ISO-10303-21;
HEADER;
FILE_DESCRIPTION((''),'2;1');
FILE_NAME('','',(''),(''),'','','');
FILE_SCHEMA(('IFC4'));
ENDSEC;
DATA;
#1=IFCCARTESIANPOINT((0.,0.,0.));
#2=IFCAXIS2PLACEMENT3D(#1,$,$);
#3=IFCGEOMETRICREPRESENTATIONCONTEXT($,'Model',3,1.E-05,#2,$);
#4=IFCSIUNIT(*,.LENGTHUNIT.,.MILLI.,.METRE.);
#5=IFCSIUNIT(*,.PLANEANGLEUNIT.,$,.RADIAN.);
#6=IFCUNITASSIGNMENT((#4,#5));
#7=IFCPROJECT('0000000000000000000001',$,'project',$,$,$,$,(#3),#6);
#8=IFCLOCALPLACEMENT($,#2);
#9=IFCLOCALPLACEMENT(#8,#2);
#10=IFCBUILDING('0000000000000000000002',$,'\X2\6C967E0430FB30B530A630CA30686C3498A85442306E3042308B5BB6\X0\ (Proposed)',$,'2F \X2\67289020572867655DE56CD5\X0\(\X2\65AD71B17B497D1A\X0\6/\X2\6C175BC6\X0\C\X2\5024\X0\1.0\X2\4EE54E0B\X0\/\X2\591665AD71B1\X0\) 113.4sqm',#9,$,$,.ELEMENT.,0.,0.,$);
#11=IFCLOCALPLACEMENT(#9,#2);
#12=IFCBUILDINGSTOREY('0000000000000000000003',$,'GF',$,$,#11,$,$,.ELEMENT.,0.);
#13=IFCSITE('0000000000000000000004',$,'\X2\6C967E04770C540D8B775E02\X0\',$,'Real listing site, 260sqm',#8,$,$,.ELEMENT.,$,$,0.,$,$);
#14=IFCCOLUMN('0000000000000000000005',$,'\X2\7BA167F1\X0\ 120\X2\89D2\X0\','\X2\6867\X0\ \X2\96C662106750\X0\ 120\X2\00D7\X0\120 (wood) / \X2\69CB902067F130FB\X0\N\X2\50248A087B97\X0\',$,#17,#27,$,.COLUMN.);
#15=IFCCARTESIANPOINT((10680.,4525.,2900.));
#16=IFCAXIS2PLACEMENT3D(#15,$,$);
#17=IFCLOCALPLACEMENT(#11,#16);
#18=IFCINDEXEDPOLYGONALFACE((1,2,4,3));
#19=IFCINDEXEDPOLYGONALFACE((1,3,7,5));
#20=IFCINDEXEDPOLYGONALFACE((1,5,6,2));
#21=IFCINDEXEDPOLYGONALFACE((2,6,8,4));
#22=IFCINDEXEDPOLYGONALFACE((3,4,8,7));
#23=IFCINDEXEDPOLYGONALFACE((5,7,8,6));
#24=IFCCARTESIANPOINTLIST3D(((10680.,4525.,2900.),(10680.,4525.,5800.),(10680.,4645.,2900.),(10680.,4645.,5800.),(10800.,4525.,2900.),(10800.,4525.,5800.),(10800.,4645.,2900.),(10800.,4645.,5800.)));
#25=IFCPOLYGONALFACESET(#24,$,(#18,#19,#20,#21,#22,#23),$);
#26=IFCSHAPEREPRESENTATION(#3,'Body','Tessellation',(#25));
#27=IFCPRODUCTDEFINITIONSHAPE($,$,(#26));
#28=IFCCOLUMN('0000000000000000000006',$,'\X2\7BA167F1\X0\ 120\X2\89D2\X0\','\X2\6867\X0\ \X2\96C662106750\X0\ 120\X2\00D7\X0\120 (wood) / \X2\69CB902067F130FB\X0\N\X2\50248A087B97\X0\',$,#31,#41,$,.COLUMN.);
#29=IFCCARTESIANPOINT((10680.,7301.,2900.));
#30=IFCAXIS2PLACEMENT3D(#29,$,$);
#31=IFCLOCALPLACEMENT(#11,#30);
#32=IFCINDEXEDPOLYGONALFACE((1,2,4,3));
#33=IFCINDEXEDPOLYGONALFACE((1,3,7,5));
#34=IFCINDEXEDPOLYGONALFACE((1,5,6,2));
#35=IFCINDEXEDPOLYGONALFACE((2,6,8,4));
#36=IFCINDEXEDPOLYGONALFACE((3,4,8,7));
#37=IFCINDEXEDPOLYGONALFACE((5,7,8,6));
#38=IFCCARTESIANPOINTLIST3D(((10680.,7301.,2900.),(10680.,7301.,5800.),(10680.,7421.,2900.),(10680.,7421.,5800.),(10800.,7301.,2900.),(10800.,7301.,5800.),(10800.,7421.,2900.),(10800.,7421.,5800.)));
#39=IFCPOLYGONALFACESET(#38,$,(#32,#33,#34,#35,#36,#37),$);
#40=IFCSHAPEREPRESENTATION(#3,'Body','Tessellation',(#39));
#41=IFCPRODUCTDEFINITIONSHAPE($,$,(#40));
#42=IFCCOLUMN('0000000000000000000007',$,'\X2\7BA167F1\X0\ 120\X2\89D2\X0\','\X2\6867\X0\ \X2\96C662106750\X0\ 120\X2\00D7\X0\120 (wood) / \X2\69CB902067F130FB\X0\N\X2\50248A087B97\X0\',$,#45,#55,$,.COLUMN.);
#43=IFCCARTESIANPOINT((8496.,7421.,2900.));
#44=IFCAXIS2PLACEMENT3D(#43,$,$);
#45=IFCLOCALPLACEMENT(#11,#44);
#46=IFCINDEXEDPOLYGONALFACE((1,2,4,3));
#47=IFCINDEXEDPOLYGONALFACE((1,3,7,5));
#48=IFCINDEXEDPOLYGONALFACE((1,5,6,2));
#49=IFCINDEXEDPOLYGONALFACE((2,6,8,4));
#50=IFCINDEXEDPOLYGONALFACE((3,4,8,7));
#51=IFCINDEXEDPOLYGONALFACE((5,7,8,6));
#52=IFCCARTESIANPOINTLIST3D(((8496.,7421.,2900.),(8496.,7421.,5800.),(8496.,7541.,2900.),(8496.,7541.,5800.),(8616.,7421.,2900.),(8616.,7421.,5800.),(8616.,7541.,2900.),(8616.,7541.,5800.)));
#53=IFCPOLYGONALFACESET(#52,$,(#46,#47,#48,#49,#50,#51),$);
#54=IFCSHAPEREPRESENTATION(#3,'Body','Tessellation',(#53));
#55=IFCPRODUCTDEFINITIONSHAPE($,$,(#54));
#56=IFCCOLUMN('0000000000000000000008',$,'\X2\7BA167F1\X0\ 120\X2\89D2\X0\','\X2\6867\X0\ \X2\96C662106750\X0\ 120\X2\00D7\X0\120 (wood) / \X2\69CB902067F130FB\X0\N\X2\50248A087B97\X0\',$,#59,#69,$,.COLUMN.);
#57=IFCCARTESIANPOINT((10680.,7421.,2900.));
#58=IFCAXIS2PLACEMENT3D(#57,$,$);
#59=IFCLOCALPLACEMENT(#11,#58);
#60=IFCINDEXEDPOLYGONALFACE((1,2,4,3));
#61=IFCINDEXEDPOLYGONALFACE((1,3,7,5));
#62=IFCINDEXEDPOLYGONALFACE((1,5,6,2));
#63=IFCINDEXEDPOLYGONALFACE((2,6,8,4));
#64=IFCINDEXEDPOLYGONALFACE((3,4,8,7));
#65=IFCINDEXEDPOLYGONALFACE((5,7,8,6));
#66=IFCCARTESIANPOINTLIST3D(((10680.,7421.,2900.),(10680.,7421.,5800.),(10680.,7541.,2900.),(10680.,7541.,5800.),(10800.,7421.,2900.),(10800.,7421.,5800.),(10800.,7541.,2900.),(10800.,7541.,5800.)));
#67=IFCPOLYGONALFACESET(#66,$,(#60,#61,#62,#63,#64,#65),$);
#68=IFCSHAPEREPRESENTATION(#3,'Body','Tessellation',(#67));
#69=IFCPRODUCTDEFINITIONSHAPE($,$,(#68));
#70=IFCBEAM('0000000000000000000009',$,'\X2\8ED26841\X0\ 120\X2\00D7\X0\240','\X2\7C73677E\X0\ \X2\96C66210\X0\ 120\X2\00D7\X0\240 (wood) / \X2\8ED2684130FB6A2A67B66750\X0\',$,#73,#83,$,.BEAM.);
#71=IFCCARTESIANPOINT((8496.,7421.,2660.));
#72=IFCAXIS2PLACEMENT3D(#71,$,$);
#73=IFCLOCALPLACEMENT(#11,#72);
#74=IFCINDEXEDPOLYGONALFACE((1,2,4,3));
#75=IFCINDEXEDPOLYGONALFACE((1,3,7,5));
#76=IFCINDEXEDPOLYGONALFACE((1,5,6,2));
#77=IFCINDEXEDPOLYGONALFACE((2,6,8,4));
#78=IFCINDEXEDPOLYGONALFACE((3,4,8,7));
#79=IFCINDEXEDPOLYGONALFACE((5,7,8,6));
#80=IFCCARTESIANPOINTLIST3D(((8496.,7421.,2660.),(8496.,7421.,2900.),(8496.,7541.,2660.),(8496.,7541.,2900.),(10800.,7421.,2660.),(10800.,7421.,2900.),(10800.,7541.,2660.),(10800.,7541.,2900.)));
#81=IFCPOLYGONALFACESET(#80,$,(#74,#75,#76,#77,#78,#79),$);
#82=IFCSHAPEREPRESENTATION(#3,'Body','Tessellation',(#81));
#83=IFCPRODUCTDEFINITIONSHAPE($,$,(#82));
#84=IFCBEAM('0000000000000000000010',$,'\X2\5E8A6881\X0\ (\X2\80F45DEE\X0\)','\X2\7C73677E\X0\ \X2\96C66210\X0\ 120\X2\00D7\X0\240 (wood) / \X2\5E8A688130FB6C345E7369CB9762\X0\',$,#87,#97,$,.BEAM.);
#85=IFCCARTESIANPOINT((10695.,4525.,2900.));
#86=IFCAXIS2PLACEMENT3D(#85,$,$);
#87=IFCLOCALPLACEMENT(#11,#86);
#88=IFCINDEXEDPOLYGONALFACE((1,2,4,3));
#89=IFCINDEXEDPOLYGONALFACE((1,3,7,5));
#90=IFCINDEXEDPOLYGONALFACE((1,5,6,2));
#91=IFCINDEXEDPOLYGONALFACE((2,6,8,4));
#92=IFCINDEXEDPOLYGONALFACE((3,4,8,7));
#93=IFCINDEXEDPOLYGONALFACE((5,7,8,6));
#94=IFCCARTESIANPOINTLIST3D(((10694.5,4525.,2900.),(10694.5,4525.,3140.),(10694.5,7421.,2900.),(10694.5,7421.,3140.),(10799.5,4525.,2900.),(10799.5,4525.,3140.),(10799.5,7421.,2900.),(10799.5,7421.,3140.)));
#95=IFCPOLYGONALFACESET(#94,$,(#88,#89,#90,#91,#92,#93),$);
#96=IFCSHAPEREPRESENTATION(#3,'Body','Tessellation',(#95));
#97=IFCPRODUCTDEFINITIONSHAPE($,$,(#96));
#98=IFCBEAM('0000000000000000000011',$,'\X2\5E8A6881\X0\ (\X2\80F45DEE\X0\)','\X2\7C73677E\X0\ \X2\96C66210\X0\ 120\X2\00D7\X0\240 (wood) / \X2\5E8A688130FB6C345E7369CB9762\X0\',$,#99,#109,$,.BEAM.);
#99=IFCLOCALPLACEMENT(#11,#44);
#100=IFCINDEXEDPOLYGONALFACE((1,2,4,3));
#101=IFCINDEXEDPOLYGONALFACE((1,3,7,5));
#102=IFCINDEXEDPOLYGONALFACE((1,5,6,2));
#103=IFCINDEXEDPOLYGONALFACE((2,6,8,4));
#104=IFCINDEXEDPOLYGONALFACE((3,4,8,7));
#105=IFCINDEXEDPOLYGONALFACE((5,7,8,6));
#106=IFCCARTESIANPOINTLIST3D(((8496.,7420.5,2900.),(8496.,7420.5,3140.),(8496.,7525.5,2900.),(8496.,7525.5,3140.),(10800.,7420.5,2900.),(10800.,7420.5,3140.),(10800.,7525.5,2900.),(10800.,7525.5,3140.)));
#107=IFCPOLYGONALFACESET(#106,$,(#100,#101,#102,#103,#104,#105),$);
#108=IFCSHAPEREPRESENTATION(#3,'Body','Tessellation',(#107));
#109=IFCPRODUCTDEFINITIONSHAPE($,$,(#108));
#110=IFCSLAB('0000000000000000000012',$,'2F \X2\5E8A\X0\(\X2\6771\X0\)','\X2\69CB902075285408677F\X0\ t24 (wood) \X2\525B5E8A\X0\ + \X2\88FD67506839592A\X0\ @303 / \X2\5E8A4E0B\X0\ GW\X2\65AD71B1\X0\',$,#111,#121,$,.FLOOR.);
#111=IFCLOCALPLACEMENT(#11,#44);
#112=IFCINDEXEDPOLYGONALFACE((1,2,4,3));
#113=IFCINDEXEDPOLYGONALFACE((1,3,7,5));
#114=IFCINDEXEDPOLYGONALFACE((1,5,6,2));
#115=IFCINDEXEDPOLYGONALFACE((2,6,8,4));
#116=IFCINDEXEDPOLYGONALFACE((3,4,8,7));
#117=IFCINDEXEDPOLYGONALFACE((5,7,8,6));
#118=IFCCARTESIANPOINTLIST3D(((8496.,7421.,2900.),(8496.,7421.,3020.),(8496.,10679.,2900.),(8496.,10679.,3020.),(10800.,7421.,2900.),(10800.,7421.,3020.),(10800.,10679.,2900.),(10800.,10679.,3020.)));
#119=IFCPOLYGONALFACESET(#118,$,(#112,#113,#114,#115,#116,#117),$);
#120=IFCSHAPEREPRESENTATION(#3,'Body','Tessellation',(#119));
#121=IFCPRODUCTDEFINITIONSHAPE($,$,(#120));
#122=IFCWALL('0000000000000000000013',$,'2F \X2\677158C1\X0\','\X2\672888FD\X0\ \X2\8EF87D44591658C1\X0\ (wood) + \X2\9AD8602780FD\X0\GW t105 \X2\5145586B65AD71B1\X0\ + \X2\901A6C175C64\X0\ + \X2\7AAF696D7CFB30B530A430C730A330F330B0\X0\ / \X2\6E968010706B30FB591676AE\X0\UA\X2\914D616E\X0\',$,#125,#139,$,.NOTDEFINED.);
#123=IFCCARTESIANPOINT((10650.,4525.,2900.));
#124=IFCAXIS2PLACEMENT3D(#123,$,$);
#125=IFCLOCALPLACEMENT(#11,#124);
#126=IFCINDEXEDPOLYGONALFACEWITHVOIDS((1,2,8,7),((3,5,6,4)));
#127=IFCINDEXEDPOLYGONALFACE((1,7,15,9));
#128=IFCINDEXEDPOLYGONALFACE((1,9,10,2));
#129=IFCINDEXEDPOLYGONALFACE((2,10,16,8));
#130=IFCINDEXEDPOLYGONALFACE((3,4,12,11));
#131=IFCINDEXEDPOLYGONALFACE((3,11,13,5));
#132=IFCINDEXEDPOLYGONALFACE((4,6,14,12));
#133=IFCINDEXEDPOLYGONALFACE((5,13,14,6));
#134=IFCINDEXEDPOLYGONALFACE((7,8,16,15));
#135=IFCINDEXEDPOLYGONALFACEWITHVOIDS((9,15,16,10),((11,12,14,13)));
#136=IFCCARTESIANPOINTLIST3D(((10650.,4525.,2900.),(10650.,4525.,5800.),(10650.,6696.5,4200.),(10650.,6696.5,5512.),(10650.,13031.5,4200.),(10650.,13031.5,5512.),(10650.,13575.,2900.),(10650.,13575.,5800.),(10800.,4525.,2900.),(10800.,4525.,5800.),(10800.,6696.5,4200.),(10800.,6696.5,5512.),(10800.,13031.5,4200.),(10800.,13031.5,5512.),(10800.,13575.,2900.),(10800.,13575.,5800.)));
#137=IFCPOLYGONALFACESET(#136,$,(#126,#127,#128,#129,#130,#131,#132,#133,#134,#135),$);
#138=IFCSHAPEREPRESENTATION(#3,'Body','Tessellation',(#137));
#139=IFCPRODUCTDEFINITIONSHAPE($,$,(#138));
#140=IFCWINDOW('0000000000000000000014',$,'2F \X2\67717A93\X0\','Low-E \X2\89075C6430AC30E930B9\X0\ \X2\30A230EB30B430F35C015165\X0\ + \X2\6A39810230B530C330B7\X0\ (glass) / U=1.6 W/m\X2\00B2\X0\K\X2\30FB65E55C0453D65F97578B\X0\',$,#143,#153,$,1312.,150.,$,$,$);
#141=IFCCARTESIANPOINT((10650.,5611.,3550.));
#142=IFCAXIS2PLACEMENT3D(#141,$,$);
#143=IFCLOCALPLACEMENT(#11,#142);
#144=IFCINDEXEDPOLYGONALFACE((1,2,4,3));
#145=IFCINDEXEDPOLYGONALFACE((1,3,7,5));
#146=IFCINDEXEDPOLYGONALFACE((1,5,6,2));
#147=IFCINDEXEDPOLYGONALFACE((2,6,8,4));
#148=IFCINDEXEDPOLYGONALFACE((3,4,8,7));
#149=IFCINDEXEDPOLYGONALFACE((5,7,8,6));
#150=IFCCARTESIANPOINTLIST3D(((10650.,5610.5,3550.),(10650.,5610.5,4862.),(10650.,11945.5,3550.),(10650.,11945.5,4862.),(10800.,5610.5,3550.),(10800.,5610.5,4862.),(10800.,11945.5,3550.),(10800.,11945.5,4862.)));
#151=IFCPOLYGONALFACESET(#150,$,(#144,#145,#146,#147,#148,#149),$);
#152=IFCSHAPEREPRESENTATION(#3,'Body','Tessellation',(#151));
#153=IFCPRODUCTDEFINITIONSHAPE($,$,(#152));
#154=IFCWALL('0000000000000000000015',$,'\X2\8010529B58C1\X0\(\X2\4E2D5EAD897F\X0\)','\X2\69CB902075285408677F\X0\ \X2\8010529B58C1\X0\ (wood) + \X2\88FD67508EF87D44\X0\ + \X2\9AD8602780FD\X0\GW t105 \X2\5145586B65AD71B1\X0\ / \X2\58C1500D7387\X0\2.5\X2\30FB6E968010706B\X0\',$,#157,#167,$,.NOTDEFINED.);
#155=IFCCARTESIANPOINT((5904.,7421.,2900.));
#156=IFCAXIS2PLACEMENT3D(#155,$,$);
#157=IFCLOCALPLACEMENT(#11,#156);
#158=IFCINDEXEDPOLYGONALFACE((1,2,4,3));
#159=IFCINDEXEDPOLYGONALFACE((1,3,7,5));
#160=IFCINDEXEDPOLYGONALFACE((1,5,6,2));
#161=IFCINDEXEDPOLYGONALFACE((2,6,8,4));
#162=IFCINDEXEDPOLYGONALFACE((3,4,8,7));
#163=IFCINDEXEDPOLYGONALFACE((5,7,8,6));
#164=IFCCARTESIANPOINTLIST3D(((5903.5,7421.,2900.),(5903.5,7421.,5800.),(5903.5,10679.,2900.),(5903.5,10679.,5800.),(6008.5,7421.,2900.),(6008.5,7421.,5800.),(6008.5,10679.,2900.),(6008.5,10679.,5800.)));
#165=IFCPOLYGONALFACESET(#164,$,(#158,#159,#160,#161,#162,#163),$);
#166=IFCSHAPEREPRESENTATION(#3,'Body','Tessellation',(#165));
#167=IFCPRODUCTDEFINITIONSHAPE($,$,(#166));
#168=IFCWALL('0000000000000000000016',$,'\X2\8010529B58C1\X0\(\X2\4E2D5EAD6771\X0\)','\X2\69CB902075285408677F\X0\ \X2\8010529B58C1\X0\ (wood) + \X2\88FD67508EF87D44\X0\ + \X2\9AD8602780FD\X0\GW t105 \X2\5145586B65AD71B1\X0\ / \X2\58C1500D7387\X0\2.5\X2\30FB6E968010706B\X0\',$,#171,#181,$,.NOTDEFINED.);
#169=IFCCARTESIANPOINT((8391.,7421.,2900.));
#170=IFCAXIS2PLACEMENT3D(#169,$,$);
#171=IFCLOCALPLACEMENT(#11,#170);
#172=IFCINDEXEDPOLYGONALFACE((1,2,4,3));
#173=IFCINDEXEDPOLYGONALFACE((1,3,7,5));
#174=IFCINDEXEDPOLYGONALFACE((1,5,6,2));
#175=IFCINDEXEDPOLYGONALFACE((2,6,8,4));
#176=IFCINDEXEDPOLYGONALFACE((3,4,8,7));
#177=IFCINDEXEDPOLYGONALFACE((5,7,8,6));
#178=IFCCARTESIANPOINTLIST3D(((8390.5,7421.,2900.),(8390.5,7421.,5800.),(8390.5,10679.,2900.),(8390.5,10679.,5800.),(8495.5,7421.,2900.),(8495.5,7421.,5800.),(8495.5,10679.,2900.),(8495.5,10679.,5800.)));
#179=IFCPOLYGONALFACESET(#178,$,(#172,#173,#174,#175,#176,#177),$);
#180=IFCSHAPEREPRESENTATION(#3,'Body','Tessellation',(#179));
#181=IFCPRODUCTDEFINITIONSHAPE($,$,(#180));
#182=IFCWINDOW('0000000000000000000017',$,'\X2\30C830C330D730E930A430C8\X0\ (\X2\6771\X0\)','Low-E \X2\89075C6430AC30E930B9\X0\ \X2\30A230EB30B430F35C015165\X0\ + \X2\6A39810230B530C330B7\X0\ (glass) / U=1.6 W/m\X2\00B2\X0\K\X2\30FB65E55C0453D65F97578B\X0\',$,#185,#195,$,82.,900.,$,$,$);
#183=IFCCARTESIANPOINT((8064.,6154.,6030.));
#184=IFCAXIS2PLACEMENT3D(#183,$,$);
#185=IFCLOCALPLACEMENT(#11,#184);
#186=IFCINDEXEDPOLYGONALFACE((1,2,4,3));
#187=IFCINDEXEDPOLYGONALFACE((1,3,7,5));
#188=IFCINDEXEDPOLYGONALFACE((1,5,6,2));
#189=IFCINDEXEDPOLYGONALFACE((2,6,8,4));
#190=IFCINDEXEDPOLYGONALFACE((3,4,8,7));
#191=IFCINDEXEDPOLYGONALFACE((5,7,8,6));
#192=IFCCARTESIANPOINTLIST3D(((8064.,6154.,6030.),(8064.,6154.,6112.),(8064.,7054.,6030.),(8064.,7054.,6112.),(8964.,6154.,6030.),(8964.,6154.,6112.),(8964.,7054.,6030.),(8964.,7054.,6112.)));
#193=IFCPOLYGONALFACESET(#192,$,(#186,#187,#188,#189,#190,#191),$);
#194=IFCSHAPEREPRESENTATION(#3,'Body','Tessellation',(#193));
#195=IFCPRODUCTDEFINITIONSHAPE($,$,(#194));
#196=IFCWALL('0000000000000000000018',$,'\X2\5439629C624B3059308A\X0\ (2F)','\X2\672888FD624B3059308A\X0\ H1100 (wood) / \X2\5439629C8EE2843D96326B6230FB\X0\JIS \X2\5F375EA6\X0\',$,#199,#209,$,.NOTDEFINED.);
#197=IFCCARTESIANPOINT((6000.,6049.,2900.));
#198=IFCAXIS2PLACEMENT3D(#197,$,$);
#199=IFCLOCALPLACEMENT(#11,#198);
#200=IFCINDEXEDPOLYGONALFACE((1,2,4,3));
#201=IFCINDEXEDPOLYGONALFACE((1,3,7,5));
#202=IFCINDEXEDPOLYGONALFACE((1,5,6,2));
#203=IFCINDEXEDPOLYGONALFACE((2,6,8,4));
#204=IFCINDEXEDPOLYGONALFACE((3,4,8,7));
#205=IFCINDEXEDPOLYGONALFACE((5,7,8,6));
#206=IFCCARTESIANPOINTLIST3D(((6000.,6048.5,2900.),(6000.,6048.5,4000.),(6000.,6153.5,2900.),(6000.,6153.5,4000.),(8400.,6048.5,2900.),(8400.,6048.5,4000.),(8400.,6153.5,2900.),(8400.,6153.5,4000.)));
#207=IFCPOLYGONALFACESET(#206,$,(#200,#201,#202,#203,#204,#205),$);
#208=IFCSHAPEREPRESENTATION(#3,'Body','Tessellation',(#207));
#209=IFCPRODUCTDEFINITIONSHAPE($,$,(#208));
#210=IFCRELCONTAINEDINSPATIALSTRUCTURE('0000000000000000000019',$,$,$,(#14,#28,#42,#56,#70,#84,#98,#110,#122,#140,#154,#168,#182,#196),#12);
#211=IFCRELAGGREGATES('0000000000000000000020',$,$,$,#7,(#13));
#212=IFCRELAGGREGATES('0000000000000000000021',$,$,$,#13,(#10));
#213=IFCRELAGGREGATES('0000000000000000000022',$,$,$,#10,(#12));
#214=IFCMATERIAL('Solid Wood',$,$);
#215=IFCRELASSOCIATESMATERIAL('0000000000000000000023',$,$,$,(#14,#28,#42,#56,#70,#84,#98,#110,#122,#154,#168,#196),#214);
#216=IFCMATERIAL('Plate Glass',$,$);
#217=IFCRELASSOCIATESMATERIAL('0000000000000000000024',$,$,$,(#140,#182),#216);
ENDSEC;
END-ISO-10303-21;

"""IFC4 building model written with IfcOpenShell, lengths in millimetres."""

from ifc_helpers import new_model, si_unit, frame, frame_2d, origin, place, context, project, spatial, rectangle, extrude, material, element, fill, save


model = new_model("IFC4")

# Units and contexts
model_context = context("Model", 3, precision=1e-05, world=origin())
ifc_project = project(units=[si_unit("LENGTHUNIT", "METRE", prefix="MILLI"), si_unit("PLANEANGLEUNIT", "RADIAN")], contexts=[model_context])

# Site, building, storey
site_placement = place(None, origin())
site = spatial("IfcSite", under=ifc_project, at=site_placement, Name="沖縄県名護市", ObjectType="Real listing site, 260sqm", CompositionType="ELEMENT", RefElevation=0.0)
building_placement = place(site_placement, origin())
building = spatial("IfcBuilding", under=site, at=building_placement, Name="沖縄・サウナと水風呂のある家 (Proposed)", ObjectType="2F 木造在来工法(断熱等級6/気密C値1.0以下/外断熱) 113.4sqm", CompositionType="ELEMENT", ElevationOfRefHeight=0.0, ElevationOfTerrain=0.0)
storey_placement = place(building_placement, origin())
storey = spatial("IfcBuildingStorey", under=building, at=storey_placement, Name="GF", CompositionType="ELEMENT", Elevation=0.0)

# Columns
ifc_material_1 = material(Name="Solid Wood")
column_1_placement = place(storey_placement, frame((10680.0, 4525.0, 2900.0)))
element("IfcColumn", 1, at=column_1_placement, inside=storey, material=ifc_material_1, Name="管柱 120角", Description="桧 集成材 120×120 (wood) / 構造柱・N値計算", PredefinedType="COLUMN", context=model_context, shape_type="SweptSolid", body=[
    extrude(rectangle(XDim=120.0, YDim=120.0, at=frame_2d((60.0, 60.0))), frame((10680.0, 4525.0, 2900.0)), (0.0, 0.0, 1.0), 2900.0),
])
column_2_placement = place(storey_placement, frame((10680.0, 7301.0, 2900.0)))
element("IfcColumn", 2, at=column_2_placement, inside=storey, material=ifc_material_1, Name="管柱 120角", Description="桧 集成材 120×120 (wood) / 構造柱・N値計算", PredefinedType="COLUMN", context=model_context, shape_type="SweptSolid", body=[
    extrude(rectangle(XDim=120.0, YDim=120.0, at=frame_2d((60.0, 60.0))), frame((10680.0, 7301.0, 2900.0)), (0.0, 0.0, 1.0), 2900.0),
])
column_3_placement = place(storey_placement, frame((8496.0, 7421.0, 2900.0)))
element("IfcColumn", 3, at=column_3_placement, inside=storey, material=ifc_material_1, Name="管柱 120角", Description="桧 集成材 120×120 (wood) / 構造柱・N値計算", PredefinedType="COLUMN", context=model_context, shape_type="SweptSolid", body=[
    extrude(rectangle(XDim=120.0, YDim=120.0, at=frame_2d((60.0, 60.0))), frame((8496.0, 7421.0, 2900.0)), (0.0, 0.0, 1.0), 2900.0),
])
column_4_placement = place(storey_placement, frame((10680.0, 7421.0, 2900.0)))
element("IfcColumn", 4, at=column_4_placement, inside=storey, material=ifc_material_1, Name="管柱 120角", Description="桧 集成材 120×120 (wood) / 構造柱・N値計算", PredefinedType="COLUMN", context=model_context, shape_type="SweptSolid", body=[
    extrude(rectangle(XDim=120.0, YDim=120.0, at=frame_2d((60.0, 60.0))), frame((10680.0, 7421.0, 2900.0)), (0.0, 0.0, 1.0), 2900.0),
])

# Beams
beam_1_placement = place(storey_placement, frame((8496.0, 7421.0, 2660.0)))
element("IfcBeam", 5, at=beam_1_placement, inside=storey, material=ifc_material_1, Name="軒桁 120×240", Description="米松 集成 120×240 (wood) / 軒桁・横架材", PredefinedType="BEAM", context=model_context, shape_type="SweptSolid", body=[
    extrude(rectangle(XDim=2304.0, YDim=120.0, at=frame_2d((1152.0, 60.0))), frame((8496.0, 7421.0, 2660.0)), (0.0, 0.0, 1.0), 240.0),
])
beam_2_placement = place(storey_placement, frame((10695.0, 4525.0, 2900.0)))
element("IfcBeam", 6, at=beam_2_placement, inside=storey, material=ifc_material_1, Name="床梁 (胴差)", Description="米松 集成 120×240 (wood) / 床梁・水平構面", PredefinedType="BEAM", context=model_context, shape_type="SweptSolid", body=[
    extrude(rectangle(XDim=105.0, YDim=2896.0, at=frame_2d((52.0, 1448.0))), frame((10695.0, 4525.0, 2900.0)), (0.0, 0.0, 1.0), 240.0),
])
beam_3_placement = place(storey_placement, frame((8496.0, 7421.0, 2900.0)))
element("IfcBeam", 7, at=beam_3_placement, inside=storey, material=ifc_material_1, Name="床梁 (胴差)", Description="米松 集成 120×240 (wood) / 床梁・水平構面", PredefinedType="BEAM", context=model_context, shape_type="SweptSolid", body=[
    extrude(rectangle(XDim=2304.0, YDim=105.0, at=frame_2d((1152.0, 52.0))), frame((8496.0, 7421.0, 2900.0)), (0.0, 0.0, 1.0), 240.0),
])

# Slab
slab_placement = place(storey_placement, frame((8496.0, 7421.0, 2900.0)))
element("IfcSlab", 8, at=slab_placement, inside=storey, material=ifc_material_1, Name="2F 床(東)", Description="構造用合板 t24 (wood) 剛床 + 製材根太 @303 / 床下 GW断熱", PredefinedType="FLOOR", context=model_context, shape_type="SweptSolid", body=[
    extrude(rectangle(XDim=2304.0, YDim=3258.0, at=frame_2d((1152.0, 1629.0))), frame((8496.0, 7421.0, 2900.0)), (0.0, 0.0, 1.0), 120.0),
])

# Wall, opening, window
wall_1_placement = place(storey_placement, frame((10650.0, 4525.0, 2900.0)))
wall_1 = element("IfcWall", 9, at=wall_1_placement, inside=storey, material=ifc_material_1, Name="2F 東壁", Description="木製 軸組外壁 (wood) + 高性能GW t105 充填断熱 + 通気層 + 窯業系サイディング / 準耐火・外皮UA配慮", PredefinedType="NOTDEFINED", context=model_context, shape_type="SweptSolid", body=[
    extrude(rectangle(XDim=150.0, YDim=9050.0, at=frame_2d((75.0, 4525.0))), frame((10650.0, 4525.0, 2900.0)), (0.0, 0.0, 1.0), 2900.0),
])
opening_placement = place(storey_placement, frame((10650.0, 5611.0, 3550.0)))
opening = element("IfcOpeningElement", 10, at=opening_placement, cuts=wall_1, PredefinedType="NOTDEFINED", context=model_context, shape_type="SweptSolid", body=[
    extrude(rectangle(XDim=150.0, YDim=6335.0, at=frame_2d((75.0, 3167.0))), frame((10650.0, 5611.0, 3550.0)), (0.0, 0.0, 1.0), 1312.0),
])
ifc_material_2 = material(Name="Plate Glass")
window_1_placement = place(storey_placement, frame((10650.0, 5611.0, 3550.0)))
window_1 = element("IfcWindow", 11, at=window_1_placement, inside=storey, material=ifc_material_2, Name="2F 東窓", Description="Low-E 複層ガラス アルゴン封入 + 樹脂サッシ (glass) / U=1.6 W/m²K・日射取得型", OverallHeight=1312.0, OverallWidth=150.0, context=model_context, shape_type="SweptSolid", body=[
    extrude(rectangle(XDim=150.0, YDim=6335.0, at=frame_2d((75.0, 3167.0))), frame((10650.0, 5611.0, 3550.0)), (0.0, 0.0, 1.0), 1312.0),
])
fill(opening, window_1)

# Walls
wall_2_placement = place(storey_placement, frame((5904.0, 7421.0, 2900.0)))
element("IfcWall", 12, at=wall_2_placement, inside=storey, material=ifc_material_1, Name="耐力壁(中庭西)", Description="構造用合板 耐力壁 (wood) + 製材軸組 + 高性能GW t105 充填断熱 / 壁倍率2.5・準耐火", PredefinedType="NOTDEFINED", context=model_context, shape_type="SweptSolid", body=[
    extrude(rectangle(XDim=105.0, YDim=3258.0, at=frame_2d((52.0, 1629.0))), frame((5904.0, 7421.0, 2900.0)), (0.0, 0.0, 1.0), 2900.0),
])
wall_3_placement = place(storey_placement, frame((8391.0, 7421.0, 2900.0)))
element("IfcWall", 13, at=wall_3_placement, inside=storey, material=ifc_material_1, Name="耐力壁(中庭東)", Description="構造用合板 耐力壁 (wood) + 製材軸組 + 高性能GW t105 充填断熱 / 壁倍率2.5・準耐火", PredefinedType="NOTDEFINED", context=model_context, shape_type="SweptSolid", body=[
    extrude(rectangle(XDim=105.0, YDim=3258.0, at=frame_2d((52.0, 1629.0))), frame((8391.0, 7421.0, 2900.0)), (0.0, 0.0, 1.0), 2900.0),
])

# Window
window_2_placement = place(storey_placement, frame((8064.0, 6154.0, 6030.0)))
element("IfcWindow", 14, at=window_2_placement, inside=storey, material=ifc_material_2, Name="トップライト (東)", Description="Low-E 複層ガラス アルゴン封入 + 樹脂サッシ (glass) / U=1.6 W/m²K・日射取得型", OverallHeight=82.0, OverallWidth=900.0, context=model_context, shape_type="SweptSolid", body=[
    extrude(rectangle(XDim=900.0, YDim=900.0, at=frame_2d((450.0, 450.0))), frame((8064.0, 6154.0, 6030.0)), (0.0, 0.0, 1.0), 82.0),
])

# Wall
wall_4_placement = place(storey_placement, frame((6000.0, 6049.0, 2900.0)))
element("IfcWall", 15, at=wall_4_placement, inside=storey, material=ifc_material_1, Name="吹抜手すり (2F)", Description="木製手すり H1100 (wood) / 吹抜転落防止・JIS 強度", PredefinedType="NOTDEFINED", context=model_context, shape_type="SweptSolid", body=[
    extrude(rectangle(XDim=2400.0, YDim=105.0, at=frame_2d((1200.0, 52.0))), frame((6000.0, 6049.0, 2900.0)), (0.0, 0.0, 1.0), 1100.0),
])

save(model, "model.ifc")
